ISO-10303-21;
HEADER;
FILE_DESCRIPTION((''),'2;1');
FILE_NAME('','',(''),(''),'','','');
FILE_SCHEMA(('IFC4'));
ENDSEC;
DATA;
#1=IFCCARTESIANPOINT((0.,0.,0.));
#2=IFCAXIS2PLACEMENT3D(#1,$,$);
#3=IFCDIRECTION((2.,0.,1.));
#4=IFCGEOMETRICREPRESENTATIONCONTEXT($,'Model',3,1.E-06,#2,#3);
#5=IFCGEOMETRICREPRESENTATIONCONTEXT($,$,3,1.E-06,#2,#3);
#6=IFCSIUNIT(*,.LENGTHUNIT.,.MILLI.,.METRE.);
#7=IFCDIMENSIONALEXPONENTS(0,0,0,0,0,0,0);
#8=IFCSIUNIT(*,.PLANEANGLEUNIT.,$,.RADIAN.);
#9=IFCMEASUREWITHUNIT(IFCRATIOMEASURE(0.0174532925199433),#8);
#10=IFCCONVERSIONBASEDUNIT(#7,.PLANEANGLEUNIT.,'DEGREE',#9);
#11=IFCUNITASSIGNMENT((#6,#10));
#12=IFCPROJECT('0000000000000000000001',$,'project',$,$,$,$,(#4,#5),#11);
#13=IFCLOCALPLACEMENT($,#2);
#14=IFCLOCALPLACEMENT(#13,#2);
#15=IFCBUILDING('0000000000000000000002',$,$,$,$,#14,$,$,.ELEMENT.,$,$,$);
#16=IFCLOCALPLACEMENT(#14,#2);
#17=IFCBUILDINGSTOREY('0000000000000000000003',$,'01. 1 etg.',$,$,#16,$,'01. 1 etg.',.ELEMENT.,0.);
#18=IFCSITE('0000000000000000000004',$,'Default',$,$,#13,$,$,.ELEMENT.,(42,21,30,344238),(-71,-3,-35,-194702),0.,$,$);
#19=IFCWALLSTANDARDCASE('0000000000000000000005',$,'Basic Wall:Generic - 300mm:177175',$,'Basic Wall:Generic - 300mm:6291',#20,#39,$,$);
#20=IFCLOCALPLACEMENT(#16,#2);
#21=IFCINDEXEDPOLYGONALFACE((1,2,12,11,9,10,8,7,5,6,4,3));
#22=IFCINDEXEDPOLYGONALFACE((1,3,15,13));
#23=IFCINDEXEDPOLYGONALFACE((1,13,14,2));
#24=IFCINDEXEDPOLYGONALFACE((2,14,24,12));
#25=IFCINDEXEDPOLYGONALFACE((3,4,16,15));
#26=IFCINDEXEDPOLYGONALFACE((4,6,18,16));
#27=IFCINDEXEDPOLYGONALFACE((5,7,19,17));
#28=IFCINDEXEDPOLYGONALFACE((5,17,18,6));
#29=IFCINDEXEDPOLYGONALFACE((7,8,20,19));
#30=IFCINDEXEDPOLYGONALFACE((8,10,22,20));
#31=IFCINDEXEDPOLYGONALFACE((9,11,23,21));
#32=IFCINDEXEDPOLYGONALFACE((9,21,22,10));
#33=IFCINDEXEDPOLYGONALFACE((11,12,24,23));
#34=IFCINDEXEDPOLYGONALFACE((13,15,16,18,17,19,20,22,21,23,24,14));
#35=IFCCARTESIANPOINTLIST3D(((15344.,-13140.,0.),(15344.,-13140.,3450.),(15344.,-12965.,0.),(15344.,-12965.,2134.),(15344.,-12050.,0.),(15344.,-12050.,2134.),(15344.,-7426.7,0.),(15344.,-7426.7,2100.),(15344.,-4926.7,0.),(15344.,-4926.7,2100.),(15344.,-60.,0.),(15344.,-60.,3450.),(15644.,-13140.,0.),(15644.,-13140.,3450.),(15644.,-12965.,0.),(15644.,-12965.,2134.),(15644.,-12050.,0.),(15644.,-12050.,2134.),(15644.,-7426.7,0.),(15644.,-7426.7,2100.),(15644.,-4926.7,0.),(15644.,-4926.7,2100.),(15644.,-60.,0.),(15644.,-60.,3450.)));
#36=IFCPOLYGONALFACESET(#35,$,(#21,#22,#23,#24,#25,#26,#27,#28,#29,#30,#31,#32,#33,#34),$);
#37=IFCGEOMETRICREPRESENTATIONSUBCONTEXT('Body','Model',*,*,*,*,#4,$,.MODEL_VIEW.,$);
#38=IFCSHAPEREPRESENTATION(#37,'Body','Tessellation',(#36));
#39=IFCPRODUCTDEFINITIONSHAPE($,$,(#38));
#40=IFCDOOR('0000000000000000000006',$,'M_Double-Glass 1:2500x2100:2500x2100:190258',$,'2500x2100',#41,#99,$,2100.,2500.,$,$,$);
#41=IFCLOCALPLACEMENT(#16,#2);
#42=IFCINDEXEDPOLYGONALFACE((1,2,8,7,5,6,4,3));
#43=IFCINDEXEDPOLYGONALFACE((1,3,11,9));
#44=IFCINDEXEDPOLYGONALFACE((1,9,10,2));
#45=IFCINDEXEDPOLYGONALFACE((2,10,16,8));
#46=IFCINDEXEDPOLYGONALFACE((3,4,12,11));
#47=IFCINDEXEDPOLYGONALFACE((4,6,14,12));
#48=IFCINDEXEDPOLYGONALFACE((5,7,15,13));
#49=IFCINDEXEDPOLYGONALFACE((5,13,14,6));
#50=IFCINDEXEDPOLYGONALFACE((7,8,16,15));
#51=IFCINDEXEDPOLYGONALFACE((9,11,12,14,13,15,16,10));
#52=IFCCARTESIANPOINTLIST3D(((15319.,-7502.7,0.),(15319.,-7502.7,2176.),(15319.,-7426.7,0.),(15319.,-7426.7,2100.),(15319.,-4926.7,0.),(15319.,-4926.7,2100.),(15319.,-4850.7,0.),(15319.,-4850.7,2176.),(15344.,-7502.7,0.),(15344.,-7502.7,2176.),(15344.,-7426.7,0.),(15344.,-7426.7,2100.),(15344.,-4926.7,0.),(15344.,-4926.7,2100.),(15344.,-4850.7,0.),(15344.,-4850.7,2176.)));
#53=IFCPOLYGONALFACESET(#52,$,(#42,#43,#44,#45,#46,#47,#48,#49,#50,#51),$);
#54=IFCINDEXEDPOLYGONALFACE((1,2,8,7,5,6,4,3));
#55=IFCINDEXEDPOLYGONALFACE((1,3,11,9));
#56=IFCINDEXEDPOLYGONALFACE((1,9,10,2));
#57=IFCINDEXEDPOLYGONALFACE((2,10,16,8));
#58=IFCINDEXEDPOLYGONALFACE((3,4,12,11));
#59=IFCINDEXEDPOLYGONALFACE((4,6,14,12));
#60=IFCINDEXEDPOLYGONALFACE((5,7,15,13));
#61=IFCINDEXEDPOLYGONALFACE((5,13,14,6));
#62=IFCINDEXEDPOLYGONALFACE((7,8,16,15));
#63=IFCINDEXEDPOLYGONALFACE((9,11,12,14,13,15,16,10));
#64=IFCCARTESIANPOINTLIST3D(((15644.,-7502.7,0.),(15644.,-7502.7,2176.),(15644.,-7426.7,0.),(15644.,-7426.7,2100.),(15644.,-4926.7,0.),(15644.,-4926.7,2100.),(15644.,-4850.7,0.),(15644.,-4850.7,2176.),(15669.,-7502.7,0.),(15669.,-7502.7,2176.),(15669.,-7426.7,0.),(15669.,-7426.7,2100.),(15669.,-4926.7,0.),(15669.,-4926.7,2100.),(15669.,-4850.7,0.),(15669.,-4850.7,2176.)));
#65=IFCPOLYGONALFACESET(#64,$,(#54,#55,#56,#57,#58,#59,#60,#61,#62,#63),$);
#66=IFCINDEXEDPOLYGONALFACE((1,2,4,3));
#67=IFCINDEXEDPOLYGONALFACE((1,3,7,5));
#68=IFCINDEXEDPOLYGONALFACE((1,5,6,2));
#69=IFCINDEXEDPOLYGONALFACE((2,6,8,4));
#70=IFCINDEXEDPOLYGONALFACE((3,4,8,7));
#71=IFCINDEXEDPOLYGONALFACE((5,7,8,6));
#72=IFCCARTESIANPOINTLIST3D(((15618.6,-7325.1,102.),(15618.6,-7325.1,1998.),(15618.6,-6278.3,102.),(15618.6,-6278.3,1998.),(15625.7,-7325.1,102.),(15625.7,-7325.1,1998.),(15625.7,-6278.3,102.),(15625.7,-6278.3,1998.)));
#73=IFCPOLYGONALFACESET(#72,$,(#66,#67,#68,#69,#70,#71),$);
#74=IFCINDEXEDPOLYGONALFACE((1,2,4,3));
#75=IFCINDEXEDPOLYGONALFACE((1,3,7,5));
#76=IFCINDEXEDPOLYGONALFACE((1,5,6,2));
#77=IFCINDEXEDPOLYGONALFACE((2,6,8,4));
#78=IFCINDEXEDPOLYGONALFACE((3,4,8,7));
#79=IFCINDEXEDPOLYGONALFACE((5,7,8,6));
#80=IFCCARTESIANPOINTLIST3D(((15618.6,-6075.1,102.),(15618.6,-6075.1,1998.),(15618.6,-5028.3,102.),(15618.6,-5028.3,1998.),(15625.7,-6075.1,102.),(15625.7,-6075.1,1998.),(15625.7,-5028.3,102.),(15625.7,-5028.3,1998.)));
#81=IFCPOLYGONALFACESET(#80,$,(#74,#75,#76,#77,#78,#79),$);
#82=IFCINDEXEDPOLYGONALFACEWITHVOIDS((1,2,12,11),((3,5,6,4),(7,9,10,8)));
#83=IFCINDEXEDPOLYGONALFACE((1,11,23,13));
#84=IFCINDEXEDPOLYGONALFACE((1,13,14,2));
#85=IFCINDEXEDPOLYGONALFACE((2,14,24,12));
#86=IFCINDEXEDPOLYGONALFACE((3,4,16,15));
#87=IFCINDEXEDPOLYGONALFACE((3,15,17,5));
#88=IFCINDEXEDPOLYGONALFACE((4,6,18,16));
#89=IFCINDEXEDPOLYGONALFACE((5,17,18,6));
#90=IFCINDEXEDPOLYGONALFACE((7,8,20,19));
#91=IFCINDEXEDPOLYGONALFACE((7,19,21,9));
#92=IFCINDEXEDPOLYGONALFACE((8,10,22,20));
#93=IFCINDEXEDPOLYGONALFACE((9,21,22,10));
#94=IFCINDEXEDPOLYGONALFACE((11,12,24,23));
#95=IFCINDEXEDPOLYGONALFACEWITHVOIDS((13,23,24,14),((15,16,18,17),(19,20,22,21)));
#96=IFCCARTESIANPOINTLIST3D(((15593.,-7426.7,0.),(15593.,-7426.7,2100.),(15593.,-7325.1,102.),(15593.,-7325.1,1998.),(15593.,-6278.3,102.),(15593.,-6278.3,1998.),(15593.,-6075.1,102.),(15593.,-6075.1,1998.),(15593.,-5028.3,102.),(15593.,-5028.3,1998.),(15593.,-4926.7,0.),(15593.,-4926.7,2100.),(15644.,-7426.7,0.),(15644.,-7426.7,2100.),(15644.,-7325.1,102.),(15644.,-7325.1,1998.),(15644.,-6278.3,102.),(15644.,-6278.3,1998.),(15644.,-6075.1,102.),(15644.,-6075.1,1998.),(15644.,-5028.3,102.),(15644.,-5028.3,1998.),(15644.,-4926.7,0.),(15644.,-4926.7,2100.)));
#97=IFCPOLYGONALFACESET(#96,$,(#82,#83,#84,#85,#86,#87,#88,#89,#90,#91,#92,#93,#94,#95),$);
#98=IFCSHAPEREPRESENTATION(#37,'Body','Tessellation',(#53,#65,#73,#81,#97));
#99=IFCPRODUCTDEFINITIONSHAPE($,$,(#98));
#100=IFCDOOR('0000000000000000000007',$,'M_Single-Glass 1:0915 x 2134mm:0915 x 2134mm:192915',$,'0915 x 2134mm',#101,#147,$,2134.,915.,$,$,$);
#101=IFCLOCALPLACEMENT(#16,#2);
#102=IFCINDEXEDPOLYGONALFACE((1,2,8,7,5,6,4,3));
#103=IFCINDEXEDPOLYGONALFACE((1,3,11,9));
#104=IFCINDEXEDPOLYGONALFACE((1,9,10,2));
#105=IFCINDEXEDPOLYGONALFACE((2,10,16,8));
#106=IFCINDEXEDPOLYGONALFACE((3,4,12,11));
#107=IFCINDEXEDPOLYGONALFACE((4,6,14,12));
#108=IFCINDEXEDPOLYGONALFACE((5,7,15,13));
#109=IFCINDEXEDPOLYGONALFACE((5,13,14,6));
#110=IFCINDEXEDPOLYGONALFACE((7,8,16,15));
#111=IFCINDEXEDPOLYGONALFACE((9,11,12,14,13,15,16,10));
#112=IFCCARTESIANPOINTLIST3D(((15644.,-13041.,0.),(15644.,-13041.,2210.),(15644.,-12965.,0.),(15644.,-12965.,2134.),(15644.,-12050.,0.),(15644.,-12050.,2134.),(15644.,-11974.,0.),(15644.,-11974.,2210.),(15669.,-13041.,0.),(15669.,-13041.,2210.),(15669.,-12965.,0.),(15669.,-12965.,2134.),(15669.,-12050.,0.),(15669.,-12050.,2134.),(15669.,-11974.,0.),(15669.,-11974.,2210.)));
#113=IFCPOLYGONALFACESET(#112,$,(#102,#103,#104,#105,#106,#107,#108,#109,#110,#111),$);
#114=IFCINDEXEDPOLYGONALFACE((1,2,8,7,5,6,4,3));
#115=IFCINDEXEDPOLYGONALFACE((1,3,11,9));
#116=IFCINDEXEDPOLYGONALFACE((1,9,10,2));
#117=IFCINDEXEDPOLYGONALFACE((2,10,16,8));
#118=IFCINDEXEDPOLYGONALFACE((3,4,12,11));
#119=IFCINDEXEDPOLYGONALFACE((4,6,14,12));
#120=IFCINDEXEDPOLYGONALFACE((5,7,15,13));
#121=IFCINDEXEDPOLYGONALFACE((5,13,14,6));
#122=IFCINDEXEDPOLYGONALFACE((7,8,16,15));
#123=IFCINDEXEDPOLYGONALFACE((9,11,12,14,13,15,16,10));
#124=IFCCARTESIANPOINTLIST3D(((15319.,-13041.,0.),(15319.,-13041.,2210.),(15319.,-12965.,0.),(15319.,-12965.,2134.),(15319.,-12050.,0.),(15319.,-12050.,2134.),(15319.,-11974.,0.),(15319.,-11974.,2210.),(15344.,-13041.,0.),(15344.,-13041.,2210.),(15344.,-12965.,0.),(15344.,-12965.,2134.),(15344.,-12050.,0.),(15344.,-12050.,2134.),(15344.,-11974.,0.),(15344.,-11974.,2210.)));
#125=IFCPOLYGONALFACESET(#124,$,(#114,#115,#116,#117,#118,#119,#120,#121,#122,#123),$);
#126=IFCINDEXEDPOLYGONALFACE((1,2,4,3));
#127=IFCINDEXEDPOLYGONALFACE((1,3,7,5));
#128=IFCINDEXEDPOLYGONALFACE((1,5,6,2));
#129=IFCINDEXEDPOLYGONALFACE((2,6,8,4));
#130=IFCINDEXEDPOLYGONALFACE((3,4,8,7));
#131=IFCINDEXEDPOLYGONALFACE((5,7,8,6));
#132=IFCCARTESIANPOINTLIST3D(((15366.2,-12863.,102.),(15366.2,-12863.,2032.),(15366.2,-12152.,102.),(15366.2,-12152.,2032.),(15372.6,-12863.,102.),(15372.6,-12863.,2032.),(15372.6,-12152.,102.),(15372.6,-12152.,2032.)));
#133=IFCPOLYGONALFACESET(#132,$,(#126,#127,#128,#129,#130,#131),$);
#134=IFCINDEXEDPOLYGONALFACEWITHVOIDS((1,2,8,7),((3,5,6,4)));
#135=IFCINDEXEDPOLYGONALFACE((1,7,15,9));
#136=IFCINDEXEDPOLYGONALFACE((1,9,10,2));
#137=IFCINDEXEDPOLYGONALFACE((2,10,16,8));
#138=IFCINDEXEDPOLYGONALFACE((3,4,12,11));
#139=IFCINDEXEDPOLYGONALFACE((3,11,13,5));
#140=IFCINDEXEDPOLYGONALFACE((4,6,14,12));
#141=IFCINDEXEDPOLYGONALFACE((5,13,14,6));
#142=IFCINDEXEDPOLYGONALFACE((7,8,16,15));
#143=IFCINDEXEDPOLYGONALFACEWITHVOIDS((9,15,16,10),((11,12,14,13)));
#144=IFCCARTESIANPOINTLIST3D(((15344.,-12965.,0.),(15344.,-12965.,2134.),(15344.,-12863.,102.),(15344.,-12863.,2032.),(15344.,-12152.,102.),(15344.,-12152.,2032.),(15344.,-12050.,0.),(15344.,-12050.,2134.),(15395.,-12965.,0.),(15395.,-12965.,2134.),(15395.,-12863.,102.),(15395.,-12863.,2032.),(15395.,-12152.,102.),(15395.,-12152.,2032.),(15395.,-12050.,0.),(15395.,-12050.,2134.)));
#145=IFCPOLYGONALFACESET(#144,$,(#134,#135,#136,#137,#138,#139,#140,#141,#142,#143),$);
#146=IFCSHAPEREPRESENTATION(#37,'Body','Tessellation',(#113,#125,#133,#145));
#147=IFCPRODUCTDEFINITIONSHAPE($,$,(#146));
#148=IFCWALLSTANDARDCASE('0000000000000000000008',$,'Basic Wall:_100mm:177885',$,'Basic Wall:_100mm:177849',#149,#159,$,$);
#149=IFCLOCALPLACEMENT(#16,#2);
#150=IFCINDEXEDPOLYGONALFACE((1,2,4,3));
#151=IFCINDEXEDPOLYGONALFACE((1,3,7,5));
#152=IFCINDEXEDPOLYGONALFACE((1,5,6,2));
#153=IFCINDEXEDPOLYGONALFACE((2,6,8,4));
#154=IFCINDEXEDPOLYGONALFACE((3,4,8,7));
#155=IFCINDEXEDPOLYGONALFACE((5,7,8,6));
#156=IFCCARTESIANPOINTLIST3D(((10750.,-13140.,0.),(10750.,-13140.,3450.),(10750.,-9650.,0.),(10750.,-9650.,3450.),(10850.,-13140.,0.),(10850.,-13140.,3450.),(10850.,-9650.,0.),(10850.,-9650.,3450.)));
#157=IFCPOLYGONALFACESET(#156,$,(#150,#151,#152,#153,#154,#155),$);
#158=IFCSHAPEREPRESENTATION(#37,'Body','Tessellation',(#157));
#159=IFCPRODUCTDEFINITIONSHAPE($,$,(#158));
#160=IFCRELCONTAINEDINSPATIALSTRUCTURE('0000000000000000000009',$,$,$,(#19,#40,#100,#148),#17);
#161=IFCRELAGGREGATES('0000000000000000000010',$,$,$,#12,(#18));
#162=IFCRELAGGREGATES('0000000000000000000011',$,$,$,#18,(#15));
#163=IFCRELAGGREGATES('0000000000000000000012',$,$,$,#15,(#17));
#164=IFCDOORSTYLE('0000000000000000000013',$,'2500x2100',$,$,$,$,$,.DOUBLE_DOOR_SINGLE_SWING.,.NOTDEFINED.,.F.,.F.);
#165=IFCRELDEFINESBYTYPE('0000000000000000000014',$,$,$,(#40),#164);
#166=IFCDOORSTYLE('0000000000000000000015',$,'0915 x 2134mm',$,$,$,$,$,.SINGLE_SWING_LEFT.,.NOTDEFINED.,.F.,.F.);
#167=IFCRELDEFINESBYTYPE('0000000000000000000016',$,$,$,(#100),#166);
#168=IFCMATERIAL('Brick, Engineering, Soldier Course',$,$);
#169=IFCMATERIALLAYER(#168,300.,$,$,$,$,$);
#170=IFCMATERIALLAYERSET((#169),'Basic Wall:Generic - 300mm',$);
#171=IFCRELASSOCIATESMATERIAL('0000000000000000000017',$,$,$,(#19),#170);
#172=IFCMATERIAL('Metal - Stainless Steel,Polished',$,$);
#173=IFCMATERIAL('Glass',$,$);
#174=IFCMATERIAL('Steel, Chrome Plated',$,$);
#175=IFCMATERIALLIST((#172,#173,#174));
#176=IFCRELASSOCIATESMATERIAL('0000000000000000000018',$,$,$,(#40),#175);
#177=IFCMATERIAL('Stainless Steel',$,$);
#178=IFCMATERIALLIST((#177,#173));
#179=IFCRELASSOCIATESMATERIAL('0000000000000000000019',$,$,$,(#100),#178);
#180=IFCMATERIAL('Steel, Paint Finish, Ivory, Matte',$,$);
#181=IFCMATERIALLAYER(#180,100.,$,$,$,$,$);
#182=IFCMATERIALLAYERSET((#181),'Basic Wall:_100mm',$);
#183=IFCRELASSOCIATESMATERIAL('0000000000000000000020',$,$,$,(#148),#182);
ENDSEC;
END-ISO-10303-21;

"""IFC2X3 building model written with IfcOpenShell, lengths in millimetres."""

from ifc_helpers import new_model, entity, si_unit, converted_unit, direction, frame, frame_2d, origin, origin_2d_with_axis, place, context, subcontext, project, spatial, polyline, rectangle, outline, extrude, clip, bounded_halfspace, source, transform, mapped, material, material_list, layer, layer_set, layer_usage, type_object, type_shapes, element, fill, save


model = new_model("IFC2X3")

# Units and contexts
model_context = context("Model", 3, precision=1e-06, world=origin(), true_north=direction((2.0, 0.0, 1.0)))
context_of_model = context(None, 3, precision=1e-06, world=origin(), true_north=direction((2.0, 0.0, 1.0)))
body_context = subcontext(model_context, "Body", "Model", "MODEL_VIEW")
ifc_project = project(units=[si_unit("LENGTHUNIT", "METRE", prefix="MILLI"), converted_unit("PLANEANGLEUNIT", "DEGREE", entity("IfcRatioMeasure", 0.0174532925199433), si_unit("PLANEANGLEUNIT", "RADIAN"), dimensions=[0, 0, 0, 0, 0, 0, 0])], contexts=[model_context, context_of_model])

# Site, building, storey
site_placement = place(None, origin())
site = spatial("IfcSite", under=ifc_project, at=site_placement, Name="Default", CompositionType="ELEMENT", RefLatitude=(42, 21, 30, 344238), RefLongitude=(-71, -3, -35, -194702), RefElevation=0.0)
building_placement = place(site_placement, origin())
building = spatial("IfcBuilding", under=site, at=building_placement, CompositionType="ELEMENT")
storey_placement = place(building_placement, origin())
storey = spatial("IfcBuildingStorey", under=building, at=storey_placement, Name="01. 1 etg.", LongName="01. 1 etg.", CompositionType="ELEMENT", Elevation=0.0)

# Shared definitions
ifc_material_1 = material(Name="Glass")

# Wall, openings, doors
ifc_material_2 = material(Name="Brick, Engineering, Soldier Course")
ifc_layer_1 = layer(ifc_material_2, 300.0)
ifc_layer_set_1 = layer_set([ifc_layer_1], Name="Basic Wall:Generic - 300mm")
ifc_layer_usage_1 = layer_usage(ifc_layer_set_1, "AXIS2", "POSITIVE", -150.0)
wall_1_placement = place(storey_placement, frame((15494.0, -13140.0, 0.0), z_axis=(0.0, 0.0, 1.0), x_axis=(0.0, 1.0, 0.0)))
wall_1 = element("IfcWallStandardCase", 1, at=wall_1_placement, inside=storey, material=ifc_layer_usage_1, Name="Basic Wall:Generic - 300mm:177175", ObjectType="Basic Wall:Generic - 300mm:6291", context=body_context, shape_type="Clipping", body=[
    clip(extrude(rectangle(XDim=13080.0, YDim=300.0, at=frame_2d((6540.0, 0.0), x_axis=(-1.0, 0.0))), origin(), (0.0, 0.0, 1.0), 3450.0), bounded_halfspace(frame((13080.0, 150.0, 3450.0), z_axis=(0.0, 0.0, -1.0), x_axis=(-1.0, 0.0, 0.0)), True, frame((13080.0, 150.0, 3450.0)), polyline([(0.0, 0.0), (-3490.0, 0.0), (-3590.0, 0.0), (-9490.0, 0.0), (-9590.0, 0.0), (-13080.0, 0.0), (-13080.0, -50.0), (-9490.0, -50.0), (-9490.0, -246.0), (-3590.0, -246.0), (0.0, -246.0), (0.0, 0.0)]))),
])
opening_1_placement = place(wall_1_placement, frame((8213.3, 150.0, 0.0)))
opening_1 = element("IfcOpeningElement", 2, at=opening_1_placement, cuts=wall_1, ObjectType="Opening", context=body_context, shape_type="SweptSolid", body=[
    extrude(rectangle(XDim=2500.0, YDim=2100.0, at=frame_2d((1050.0, 1250.0), x_axis=(0.0, 1.0))), frame((0.0, 0.0, 0.0), z_axis=(0.0, -1.0, 0.0), x_axis=(0.0, 0.0, 1.0)), (0.0, 0.0, 1.0), 300.0),
])
opening_2_placement = place(wall_1_placement, frame((175.0, -150.0, 0.0)))
opening_2 = element("IfcOpeningElement", 3, at=opening_2_placement, cuts=wall_1, ObjectType="Opening", context=body_context, shape_type="SweptSolid", body=[
    extrude(rectangle(XDim=915.0, YDim=2134.0, at=frame_2d((1067.0, 457.5), x_axis=(0.0, -1.0))), frame((0.0, 0.0, 0.0), z_axis=(0.0, 1.0, 0.0), x_axis=(0.0, 0.0, 1.0)), (0.0, 0.0, 1.0), 300.0),
])
ifc_material_3 = material(Name="Metal - Stainless Steel,Polished")
ifc_material_4 = material(Name="Steel, Chrome Plated")
ifc_material_list_1 = material_list([ifc_material_3, ifc_material_1, ifc_material_4])
door_style_1 = type_object("IfcDoorStyle", Name="2500x2100", ConstructionType="NOTDEFINED", OperationType="DOUBLE_DOOR_SINGLE_SWING", ParameterTakesPrecedence=False, Sizeable=False)
shared_shape_1 = source(origin(), body_context, "Body", "SweptSolid", [
    extrude(outline(polyline([(-1326.0, -1069.0), (-1250.0, -1069.0), (-1250.0, 1031.0), (1250.0, 1031.0), (1250.0, -1069.0), (1326.0, -1069.0), (1326.0, 1107.0), (-1326.0, 1107.0), (-1326.0, -1069.0)])), frame((1250.0, -25.0, 1069.0), z_axis=(0.0, 1.0, 0.0), x_axis=(-1.0, 0.0, 0.0)), (0.0, 0.0, 1.0), 25.0),
    extrude(outline(polyline([(-1250.0, -1031.0), (-1250.0, 1069.0), (-1326.0, 1069.0), (-1326.0, -1107.0), (1326.0, -1107.0), (1326.0, 1069.0), (1250.0, 1069.0), (1250.0, -1031.0), (-1250.0, -1031.0)])), frame((1250.0, 300.0, 1069.0), z_axis=(0.0, -1.0, 0.0), x_axis=(-1.0, 0.0, 0.0)), (0.0, 0.0, -1.0), 25.0),
    extrude(rectangle(XDim=7.1, YDim=1046.8, at=frame_2d((0.0, 0.0), x_axis=(1.0, 0.0))), frame((1875.0, 278.2, 102.0), z_axis=(0.0, 0.0, 1.0), x_axis=(0.0, 1.0, 0.0)), (0.0, 0.0, 1.0), 1896.0),
    extrude(rectangle(XDim=7.1, YDim=1046.8, at=frame_2d((0.0, 0.0), x_axis=(1.0, 0.0))), frame((625.0, 278.2, 102.0), z_axis=(0.0, 0.0, 1.0), x_axis=(0.0, 1.0, 0.0)), (0.0, 0.0, 1.0), 1896.0),
    extrude(outline(polyline([(-1050.0, -1250.0), (1050.0, -1250.0), (1050.0, 1250.0), (-1050.0, 1250.0), (-1050.0, -1250.0)]), holes=[polyline([(-948.0, 101.6), (-948.0, 1148.4), (948.0, 1148.4), (948.0, 101.6), (-948.0, 101.6)]), polyline([(-948.0, -1148.4), (-948.0, -101.6), (948.0, -101.6), (948.0, -1148.4), (-948.0, -1148.4)])]), frame((1250.0, 249.0, 1050.0), z_axis=(0.0, 1.0, 0.0), x_axis=(0.0, 0.0, -1.0)), (0.0, 0.0, 1.0), 51.0),
])
type_shapes(door_style_1, [shared_shape_1])
door_1_placement = place(opening_1_placement, frame((0.0, 0.0, 0.0), z_axis=(0.0, 0.0, 1.0), x_axis=(-1.0, 0.0, 0.0)))
door_1 = element("IfcDoor", 4, at=door_1_placement, inside=storey, type_object=door_style_1, material=ifc_material_list_1, Name="M_Double-Glass 1:2500x2100:2500x2100:190258", ObjectType="2500x2100", OverallHeight=2100.0, OverallWidth=2500.0, context=body_context, shape_type="MappedRepresentation", body=[
    mapped(shared_shape_1, transform((0.0, 0.0, 0.0), scale=1.0)),
])
fill(opening_1, door_1)
ifc_material_5 = material(Name="Stainless Steel")
ifc_material_list_2 = material_list([ifc_material_5, ifc_material_1])
door_style_2 = type_object("IfcDoorStyle", Name="0915 x 2134mm", ConstructionType="NOTDEFINED", OperationType="SINGLE_SWING_LEFT", ParameterTakesPrecedence=False, Sizeable=False)
shared_shape_2 = source(origin(), body_context, "Body", "SweptSolid", [
    extrude(outline(polyline([(-457.5, -1048.0), (-457.5, 1086.0), (-533.5, 1086.0), (-533.5, -1124.0), (533.5, -1124.0), (533.5, 1086.0), (457.5, 1086.0), (457.5, -1048.0), (-457.5, -1048.0)])), frame((457.5, 0.0, 1086.0), z_axis=(0.0, 1.0, 0.0), x_axis=(1.0, 0.0, 0.0)), (0.0, 0.0, -1.0), 25.0),
    extrude(outline(polyline([(-457.5, -1048.0), (-457.5, 1086.0), (-533.5, 1086.0), (-533.5, -1124.0), (533.5, -1124.0), (533.5, 1086.0), (457.5, 1086.0), (457.5, -1048.0), (-457.5, -1048.0)])), frame((457.5, 325.0, 1086.0), z_axis=(0.0, 1.0, 0.0), x_axis=(1.0, 0.0, 0.0)), (0.0, 0.0, -1.0), 25.0),
    extrude(rectangle(XDim=711.0, YDim=6.4, at=origin_2d_with_axis()), frame((457.5, 274.6, 102.0)), (0.0, 0.0, 1.0), 1930.0),
    extrude(outline(polyline([(-1067.0, -457.5), (1067.0, -457.5), (1067.0, 457.5), (-1067.0, 457.5), (-1067.0, -457.5)]), holes=[polyline([(-965.0, 355.5), (965.0, 355.5), (965.0, -355.5), (-965.0, -355.5), (-965.0, 355.5)])]), frame((457.5, 300.0, 1067.0), z_axis=(0.0, -1.0, 0.0), x_axis=(0.0, 0.0, -1.0)), (0.0, 0.0, 1.0), 51.0),
])
type_shapes(door_style_2, [shared_shape_2])
door_2_placement = place(opening_2_placement, origin())
door_2 = element("IfcDoor", 5, at=door_2_placement, inside=storey, type_object=door_style_2, material=ifc_material_list_2, Name="M_Single-Glass 1:0915 x 2134mm:0915 x 2134mm:192915", ObjectType="0915 x 2134mm", OverallHeight=2134.0, OverallWidth=915.0, context=body_context, shape_type="MappedRepresentation", body=[
    mapped(shared_shape_2, transform((0.0, 0.0, 0.0), scale=1.0)),
])
fill(opening_2, door_2)

# Wall
ifc_material_6 = material(Name="Steel, Paint Finish, Ivory, Matte")
ifc_layer_2 = layer(ifc_material_6, 100.0)
ifc_layer_set_2 = layer_set([ifc_layer_2], Name="Basic Wall:_100mm")
ifc_layer_usage_2 = layer_usage(ifc_layer_set_2, "AXIS2", "NEGATIVE", 50.0)
wall_2_placement = place(storey_placement, frame((10800.0, -13140.0, 0.0), z_axis=(0.0, 0.0, 1.0), x_axis=(0.0, 1.0, 0.0)))
element("IfcWallStandardCase", 6, at=wall_2_placement, inside=storey, material=ifc_layer_usage_2, Name="Basic Wall:_100mm:177885", ObjectType="Basic Wall:_100mm:177849", context=body_context, shape_type="Clipping", body=[
    clip(extrude(rectangle(XDim=3490.0, YDim=100.0, at=frame_2d((1745.0, 0.0), x_axis=(-1.0, 0.0))), origin(), (0.0, 0.0, 1.0), 3450.0), bounded_halfspace(frame((0.0, -50.0, 3450.0), z_axis=(0.0, 0.0, -1.0), x_axis=(-1.0, 0.0, 0.0)), True, frame((0.0, -50.0, 3450.0)), polyline([(0.0, 0.0), (3490.0, 0.0), (3490.0, 100.0), (0.0, 100.0), (0.0, 0.0)]))),
])

save(model, "model.ifc")
